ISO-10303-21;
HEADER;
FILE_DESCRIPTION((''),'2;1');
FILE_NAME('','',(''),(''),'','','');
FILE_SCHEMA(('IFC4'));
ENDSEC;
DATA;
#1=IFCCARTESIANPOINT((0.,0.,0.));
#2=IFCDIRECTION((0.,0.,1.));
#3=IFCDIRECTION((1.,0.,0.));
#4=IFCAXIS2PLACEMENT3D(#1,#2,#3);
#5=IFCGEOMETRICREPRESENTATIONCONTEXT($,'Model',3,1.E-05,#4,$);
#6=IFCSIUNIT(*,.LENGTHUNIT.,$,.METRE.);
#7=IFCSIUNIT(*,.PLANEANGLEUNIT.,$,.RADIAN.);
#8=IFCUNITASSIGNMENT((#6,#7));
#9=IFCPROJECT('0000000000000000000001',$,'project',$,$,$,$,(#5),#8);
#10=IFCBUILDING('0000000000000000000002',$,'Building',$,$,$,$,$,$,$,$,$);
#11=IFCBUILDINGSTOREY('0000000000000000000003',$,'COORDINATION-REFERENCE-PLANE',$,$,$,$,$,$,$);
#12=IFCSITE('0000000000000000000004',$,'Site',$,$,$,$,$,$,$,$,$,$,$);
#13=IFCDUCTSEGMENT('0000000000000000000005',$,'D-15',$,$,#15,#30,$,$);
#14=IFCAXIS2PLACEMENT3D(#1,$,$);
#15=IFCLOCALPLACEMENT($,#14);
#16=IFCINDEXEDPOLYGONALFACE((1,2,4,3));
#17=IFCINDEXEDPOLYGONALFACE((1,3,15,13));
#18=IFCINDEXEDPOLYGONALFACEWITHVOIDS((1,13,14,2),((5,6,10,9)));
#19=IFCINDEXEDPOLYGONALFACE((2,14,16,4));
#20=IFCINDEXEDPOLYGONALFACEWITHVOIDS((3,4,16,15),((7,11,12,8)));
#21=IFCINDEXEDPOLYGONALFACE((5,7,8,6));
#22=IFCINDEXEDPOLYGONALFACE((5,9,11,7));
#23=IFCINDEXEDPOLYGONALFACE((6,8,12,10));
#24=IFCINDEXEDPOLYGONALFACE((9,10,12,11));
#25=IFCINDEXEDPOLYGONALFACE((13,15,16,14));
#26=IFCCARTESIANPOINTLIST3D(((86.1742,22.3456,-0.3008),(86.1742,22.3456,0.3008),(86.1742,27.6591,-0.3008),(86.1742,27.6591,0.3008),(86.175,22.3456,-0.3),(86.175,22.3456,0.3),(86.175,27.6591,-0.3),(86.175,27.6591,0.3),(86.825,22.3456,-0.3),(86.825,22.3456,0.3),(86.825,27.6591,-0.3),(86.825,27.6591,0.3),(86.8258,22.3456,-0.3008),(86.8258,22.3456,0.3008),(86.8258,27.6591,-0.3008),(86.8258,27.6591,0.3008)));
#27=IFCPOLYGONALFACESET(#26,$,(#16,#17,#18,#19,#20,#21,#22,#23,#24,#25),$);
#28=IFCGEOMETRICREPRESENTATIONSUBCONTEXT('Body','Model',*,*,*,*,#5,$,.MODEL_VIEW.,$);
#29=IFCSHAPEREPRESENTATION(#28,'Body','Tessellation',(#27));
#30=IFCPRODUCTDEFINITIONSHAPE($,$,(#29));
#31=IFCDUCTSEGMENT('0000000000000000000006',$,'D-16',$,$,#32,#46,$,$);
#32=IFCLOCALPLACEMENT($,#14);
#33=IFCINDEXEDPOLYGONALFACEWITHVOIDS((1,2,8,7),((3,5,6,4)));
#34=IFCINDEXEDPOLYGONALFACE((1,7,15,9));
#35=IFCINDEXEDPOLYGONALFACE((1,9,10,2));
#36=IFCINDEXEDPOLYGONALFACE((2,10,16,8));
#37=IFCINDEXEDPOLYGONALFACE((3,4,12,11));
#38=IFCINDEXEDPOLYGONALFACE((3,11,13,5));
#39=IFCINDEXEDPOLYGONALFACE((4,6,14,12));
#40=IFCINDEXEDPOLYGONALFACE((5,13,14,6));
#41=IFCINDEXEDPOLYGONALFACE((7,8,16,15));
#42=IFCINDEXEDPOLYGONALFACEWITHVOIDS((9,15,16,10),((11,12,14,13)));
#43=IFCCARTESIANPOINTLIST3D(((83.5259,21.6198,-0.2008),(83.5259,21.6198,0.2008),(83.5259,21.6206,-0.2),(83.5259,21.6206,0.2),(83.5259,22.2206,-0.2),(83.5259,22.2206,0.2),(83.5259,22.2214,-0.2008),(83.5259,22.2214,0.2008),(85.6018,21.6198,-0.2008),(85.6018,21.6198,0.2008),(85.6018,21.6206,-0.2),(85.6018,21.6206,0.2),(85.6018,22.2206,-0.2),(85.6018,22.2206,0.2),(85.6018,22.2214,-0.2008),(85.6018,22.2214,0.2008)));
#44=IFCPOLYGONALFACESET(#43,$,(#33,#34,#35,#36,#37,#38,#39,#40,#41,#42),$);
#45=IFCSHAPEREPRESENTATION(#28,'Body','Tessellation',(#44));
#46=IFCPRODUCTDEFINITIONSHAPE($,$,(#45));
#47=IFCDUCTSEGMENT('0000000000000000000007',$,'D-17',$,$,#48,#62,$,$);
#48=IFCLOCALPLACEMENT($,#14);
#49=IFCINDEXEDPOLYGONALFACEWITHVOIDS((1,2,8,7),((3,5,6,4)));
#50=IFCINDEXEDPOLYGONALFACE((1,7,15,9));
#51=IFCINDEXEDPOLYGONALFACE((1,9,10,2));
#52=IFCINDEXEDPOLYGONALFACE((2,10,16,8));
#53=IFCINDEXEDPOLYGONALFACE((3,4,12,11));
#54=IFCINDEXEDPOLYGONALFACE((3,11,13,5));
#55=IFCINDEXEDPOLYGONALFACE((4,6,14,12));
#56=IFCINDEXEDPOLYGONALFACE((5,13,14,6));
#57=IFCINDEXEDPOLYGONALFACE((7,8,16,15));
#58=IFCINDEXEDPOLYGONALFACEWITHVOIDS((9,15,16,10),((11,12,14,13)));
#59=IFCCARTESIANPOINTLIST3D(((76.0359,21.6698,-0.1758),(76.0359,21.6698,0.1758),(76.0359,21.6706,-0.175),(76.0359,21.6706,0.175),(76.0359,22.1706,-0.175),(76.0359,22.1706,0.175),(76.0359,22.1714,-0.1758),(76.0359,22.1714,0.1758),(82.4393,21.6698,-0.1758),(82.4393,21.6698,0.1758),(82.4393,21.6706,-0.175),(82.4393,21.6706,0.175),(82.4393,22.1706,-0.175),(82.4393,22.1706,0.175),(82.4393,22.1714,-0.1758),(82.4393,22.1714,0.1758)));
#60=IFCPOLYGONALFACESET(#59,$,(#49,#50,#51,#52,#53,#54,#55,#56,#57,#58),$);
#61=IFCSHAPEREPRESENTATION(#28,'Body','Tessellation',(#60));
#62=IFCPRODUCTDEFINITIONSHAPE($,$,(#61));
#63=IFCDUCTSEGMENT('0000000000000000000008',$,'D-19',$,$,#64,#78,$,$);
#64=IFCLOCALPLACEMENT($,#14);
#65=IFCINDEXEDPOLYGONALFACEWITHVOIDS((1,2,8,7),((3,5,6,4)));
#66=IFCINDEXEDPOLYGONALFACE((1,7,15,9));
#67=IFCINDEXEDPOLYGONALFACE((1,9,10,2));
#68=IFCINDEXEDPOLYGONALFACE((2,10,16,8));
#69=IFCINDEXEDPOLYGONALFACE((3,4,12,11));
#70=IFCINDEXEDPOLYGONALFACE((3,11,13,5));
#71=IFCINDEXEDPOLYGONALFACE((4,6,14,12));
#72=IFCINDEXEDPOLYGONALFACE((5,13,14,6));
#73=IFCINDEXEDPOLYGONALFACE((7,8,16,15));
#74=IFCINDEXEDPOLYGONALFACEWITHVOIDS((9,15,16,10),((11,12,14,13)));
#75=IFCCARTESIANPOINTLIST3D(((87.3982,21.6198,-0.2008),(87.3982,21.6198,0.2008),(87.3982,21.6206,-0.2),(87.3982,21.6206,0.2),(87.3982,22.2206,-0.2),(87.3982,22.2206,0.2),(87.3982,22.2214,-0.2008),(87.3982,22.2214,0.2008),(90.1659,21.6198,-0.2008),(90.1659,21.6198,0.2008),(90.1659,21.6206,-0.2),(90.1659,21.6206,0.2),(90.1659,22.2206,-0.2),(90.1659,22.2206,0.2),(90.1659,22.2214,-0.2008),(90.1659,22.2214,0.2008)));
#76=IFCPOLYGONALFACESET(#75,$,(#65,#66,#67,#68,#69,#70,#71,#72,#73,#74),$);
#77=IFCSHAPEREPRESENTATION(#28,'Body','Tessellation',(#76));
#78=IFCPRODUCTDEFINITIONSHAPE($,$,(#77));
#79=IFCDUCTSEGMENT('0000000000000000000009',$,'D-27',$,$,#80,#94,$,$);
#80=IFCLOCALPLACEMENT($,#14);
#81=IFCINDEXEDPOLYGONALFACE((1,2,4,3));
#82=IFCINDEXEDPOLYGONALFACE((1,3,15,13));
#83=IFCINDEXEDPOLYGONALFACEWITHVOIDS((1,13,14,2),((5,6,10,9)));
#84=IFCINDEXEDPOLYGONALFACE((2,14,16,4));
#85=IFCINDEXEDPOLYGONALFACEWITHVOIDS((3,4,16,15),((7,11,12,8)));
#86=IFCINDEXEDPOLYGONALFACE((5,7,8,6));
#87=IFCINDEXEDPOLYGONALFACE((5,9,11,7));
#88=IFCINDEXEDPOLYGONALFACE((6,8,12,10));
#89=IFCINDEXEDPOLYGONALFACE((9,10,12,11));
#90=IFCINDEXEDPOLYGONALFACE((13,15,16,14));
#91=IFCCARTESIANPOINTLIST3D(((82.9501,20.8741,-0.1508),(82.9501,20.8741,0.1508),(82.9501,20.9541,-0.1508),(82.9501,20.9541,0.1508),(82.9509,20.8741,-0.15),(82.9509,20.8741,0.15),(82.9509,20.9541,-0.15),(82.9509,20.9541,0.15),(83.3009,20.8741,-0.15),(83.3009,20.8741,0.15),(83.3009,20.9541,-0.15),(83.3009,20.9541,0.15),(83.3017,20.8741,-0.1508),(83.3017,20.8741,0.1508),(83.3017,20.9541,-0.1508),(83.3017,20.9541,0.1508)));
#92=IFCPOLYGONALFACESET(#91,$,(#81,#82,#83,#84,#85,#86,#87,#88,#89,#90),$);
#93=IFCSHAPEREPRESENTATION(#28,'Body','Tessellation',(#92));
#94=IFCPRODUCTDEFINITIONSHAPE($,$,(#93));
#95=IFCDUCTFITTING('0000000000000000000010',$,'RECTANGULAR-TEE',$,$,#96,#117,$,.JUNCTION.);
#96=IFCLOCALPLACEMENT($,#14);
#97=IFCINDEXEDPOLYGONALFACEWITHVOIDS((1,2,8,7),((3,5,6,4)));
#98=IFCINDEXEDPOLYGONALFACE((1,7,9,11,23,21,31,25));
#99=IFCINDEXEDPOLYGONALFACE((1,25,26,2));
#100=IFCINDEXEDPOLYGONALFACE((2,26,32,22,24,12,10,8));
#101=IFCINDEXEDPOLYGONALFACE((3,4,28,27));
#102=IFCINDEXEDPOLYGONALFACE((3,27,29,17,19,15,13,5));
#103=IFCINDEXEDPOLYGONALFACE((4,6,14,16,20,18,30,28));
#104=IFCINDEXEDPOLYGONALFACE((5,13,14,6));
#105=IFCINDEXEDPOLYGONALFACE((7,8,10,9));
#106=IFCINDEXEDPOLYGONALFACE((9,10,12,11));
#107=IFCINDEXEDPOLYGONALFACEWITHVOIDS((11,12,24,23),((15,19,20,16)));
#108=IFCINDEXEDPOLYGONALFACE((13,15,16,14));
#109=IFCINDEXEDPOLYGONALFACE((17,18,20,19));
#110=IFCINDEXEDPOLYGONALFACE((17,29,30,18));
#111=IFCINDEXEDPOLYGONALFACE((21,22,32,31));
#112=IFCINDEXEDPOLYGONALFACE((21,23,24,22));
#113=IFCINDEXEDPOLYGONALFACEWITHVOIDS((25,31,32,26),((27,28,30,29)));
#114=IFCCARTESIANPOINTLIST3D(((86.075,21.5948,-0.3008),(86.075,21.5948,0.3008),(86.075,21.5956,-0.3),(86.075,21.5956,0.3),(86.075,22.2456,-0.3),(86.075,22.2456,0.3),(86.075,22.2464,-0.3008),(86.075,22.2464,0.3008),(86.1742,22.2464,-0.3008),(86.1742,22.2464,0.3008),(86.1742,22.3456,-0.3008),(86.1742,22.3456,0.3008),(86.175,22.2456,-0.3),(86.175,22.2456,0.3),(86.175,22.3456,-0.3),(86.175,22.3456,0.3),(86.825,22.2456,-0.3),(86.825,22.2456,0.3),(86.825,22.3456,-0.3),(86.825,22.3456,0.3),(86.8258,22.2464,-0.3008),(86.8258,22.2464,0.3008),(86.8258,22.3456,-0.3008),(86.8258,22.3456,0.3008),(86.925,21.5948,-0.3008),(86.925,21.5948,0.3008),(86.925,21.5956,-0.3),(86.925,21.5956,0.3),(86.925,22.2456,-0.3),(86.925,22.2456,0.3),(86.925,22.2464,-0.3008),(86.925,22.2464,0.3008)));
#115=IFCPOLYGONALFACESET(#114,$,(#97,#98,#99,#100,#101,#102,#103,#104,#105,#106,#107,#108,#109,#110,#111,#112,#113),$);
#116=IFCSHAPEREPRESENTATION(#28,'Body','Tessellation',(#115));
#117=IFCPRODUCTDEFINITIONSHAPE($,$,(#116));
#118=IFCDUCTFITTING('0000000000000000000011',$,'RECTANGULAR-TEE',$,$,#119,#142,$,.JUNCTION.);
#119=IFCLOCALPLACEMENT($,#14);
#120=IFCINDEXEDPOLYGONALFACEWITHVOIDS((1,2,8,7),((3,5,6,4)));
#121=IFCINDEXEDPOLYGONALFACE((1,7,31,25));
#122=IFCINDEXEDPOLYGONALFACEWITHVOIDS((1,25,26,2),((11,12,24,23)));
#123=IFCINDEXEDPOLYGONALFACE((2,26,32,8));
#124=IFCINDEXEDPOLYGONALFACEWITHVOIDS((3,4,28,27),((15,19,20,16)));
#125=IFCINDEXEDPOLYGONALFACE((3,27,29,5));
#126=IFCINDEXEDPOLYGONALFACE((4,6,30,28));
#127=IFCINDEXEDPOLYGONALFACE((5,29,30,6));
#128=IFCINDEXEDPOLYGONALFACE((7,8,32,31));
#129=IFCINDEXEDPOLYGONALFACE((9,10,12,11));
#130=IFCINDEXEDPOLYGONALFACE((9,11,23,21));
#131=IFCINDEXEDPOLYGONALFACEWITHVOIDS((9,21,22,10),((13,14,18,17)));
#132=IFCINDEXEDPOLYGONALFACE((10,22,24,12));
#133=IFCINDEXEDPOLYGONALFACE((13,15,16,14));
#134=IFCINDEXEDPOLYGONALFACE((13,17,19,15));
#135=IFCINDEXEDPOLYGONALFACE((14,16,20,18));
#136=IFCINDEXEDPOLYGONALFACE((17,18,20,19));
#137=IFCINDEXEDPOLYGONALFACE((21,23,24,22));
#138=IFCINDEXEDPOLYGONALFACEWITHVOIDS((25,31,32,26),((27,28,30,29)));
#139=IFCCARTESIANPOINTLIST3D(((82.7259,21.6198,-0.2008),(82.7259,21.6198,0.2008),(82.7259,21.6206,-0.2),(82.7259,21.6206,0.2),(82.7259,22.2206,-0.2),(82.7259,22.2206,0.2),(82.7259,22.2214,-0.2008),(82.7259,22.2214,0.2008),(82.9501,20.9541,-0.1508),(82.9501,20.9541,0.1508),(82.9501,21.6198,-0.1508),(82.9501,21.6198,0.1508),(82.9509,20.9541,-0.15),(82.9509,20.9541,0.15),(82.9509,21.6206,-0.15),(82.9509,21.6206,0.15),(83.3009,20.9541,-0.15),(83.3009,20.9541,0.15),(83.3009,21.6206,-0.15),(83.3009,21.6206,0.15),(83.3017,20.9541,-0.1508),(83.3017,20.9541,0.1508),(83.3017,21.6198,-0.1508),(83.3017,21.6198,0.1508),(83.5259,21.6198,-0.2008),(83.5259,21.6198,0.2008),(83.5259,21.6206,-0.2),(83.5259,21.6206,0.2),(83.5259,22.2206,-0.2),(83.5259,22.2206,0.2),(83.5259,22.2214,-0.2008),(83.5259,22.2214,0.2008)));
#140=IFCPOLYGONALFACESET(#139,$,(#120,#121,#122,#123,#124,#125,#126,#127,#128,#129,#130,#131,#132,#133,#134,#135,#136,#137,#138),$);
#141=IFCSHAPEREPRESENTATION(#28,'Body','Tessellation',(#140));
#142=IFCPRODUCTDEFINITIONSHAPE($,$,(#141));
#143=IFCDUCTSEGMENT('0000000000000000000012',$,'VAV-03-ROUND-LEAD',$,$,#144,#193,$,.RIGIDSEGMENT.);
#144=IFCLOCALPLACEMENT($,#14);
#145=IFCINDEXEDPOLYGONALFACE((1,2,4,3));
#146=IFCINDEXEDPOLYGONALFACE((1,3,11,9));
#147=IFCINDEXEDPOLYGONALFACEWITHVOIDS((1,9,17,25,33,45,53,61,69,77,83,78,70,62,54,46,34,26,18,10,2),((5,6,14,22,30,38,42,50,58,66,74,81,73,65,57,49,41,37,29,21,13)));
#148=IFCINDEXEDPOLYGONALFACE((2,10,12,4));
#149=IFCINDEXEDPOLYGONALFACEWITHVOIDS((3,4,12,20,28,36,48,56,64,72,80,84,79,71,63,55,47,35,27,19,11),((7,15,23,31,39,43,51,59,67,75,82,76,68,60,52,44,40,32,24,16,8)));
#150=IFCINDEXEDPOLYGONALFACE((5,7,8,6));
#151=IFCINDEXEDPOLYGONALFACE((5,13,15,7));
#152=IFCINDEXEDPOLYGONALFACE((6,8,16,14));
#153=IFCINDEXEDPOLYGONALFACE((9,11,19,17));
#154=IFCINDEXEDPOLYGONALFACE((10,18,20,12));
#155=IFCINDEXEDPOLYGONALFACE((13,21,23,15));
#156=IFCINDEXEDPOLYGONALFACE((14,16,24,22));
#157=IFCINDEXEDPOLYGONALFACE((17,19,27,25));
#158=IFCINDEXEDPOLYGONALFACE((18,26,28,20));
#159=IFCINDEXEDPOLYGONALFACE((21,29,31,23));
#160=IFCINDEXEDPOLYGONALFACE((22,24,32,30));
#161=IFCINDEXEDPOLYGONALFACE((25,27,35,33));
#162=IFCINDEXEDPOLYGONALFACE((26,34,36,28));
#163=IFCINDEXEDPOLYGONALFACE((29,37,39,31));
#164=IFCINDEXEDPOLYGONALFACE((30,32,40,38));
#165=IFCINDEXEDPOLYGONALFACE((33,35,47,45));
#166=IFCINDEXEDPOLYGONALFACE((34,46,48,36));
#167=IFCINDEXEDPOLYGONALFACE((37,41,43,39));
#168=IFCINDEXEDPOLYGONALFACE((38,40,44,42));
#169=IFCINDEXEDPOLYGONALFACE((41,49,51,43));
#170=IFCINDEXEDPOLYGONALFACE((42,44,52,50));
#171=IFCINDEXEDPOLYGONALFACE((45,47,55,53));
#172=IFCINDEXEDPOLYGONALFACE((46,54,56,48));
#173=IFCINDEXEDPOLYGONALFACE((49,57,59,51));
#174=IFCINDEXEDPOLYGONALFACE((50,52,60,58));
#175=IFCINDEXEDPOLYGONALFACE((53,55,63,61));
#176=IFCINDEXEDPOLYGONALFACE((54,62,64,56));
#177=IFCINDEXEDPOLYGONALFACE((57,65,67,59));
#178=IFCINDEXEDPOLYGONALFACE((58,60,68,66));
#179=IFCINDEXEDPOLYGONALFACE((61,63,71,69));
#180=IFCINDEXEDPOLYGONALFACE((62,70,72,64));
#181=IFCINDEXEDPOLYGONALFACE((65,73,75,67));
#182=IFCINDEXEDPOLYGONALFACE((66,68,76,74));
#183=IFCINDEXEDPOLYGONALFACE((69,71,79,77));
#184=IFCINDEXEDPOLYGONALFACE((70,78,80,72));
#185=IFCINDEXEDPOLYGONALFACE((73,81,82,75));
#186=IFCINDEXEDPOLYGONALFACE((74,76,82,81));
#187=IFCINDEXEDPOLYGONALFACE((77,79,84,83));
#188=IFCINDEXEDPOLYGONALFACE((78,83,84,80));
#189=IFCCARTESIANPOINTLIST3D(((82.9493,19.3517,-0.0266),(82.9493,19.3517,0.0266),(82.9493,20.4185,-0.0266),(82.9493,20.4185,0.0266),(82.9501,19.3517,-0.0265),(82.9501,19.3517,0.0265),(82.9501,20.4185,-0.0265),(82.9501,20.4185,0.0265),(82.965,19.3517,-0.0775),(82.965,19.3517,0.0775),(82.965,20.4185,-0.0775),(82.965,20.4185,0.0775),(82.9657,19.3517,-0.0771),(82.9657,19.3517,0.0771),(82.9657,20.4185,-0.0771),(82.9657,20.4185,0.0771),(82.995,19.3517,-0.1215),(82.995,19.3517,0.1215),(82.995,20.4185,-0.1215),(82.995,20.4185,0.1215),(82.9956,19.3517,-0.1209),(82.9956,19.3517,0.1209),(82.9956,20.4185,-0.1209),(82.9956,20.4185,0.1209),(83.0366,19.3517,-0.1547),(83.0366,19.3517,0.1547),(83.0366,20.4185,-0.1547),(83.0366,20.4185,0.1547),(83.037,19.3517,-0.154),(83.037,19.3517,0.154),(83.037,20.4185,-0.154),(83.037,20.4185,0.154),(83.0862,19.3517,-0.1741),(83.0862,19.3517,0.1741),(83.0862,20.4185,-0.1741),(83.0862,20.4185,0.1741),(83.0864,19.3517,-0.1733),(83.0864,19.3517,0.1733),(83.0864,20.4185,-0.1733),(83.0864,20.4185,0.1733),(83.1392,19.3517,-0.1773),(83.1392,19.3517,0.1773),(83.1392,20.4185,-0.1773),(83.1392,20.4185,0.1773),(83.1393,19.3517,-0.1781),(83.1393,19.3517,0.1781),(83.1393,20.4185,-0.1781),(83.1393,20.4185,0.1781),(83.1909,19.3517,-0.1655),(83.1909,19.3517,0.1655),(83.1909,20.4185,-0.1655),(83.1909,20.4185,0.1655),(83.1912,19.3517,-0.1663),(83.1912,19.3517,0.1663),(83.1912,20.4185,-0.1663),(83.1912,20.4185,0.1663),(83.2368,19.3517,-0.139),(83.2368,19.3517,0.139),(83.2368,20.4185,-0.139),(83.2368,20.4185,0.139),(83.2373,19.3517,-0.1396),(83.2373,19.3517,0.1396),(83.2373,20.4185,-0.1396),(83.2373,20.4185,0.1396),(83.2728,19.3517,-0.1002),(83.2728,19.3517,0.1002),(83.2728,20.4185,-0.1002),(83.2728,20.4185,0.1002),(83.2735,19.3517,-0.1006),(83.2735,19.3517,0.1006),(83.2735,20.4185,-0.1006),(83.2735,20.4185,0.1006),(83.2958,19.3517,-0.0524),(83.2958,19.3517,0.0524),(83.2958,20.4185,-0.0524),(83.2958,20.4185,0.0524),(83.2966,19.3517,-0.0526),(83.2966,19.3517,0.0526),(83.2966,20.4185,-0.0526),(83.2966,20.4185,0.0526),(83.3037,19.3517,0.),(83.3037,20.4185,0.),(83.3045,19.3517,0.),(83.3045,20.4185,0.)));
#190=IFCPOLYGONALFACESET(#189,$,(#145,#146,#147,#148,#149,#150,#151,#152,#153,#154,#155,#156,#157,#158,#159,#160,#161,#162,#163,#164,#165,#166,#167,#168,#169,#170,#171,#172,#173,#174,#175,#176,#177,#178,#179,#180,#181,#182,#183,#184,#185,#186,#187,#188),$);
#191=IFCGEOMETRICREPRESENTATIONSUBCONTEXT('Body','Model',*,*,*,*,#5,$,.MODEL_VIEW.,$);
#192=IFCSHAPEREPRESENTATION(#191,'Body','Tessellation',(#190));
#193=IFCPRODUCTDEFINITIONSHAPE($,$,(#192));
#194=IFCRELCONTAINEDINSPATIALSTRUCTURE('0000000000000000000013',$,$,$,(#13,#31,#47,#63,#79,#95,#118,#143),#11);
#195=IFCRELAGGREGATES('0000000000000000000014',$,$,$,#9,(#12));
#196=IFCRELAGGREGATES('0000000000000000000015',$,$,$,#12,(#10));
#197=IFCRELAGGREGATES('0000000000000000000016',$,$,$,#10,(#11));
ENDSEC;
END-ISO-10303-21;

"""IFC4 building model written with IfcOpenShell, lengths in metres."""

from ifc_helpers import new_model, si_unit, frame, origin, origin_with_axes, place, context, subcontext, project, spatial, rectangle, hollow_rectangle, hollow_circle, extrude, boolean, element, save


model = new_model("IFC4")

# Units and contexts
model_context = context("Model", 3, precision=1e-05, world=origin_with_axes())
body_context_1 = subcontext(model_context, "Body", "Model", "MODEL_VIEW")
body_context_2 = subcontext(model_context, "Body", "Model", "MODEL_VIEW")
ifc_project = project(units=[si_unit("LENGTHUNIT", "METRE"), si_unit("PLANEANGLEUNIT", "RADIAN")], contexts=[model_context])

# Site, building, storey
site = spatial("IfcSite", under=ifc_project, Name="Site")
building = spatial("IfcBuilding", under=site, Name="Building")
storey = spatial("IfcBuildingStorey", under=building, Name="COORDINATION-REFERENCE-PLANE")

# Duct segments
duct_segment_1_placement = place(None, frame((86.5, 22.3456, 0.0), z_axis=(0.0, 1.0, 0.0), x_axis=(1.0, 0.0, 0.0)))
element("IfcDuctSegment", 1, at=duct_segment_1_placement, inside=storey, Name="D-15", context=body_context_1, shape_type="SweptSolid", body=[
    extrude(hollow_rectangle(XDim=0.6516, YDim=0.6016, WallThickness=0.0008), origin(), (0.0, 0.0, 1.0), 5.3135),
])
duct_segment_2_placement = place(None, frame((83.5259, 21.9206, 0.0), z_axis=(1.0, 0.0, 0.0), x_axis=(0.0, 1.0, 0.0)))
element("IfcDuctSegment", 2, at=duct_segment_2_placement, inside=storey, Name="D-16", context=body_context_1, shape_type="SweptSolid", body=[
    extrude(hollow_rectangle(XDim=0.6016, YDim=0.4016, WallThickness=0.0008), origin(), (0.0, 0.0, 1.0), 2.0759),
])
duct_segment_3_placement = place(None, frame((76.0359, 21.9206, 0.0), z_axis=(1.0, 0.0, 0.0), x_axis=(0.0, 1.0, 0.0)))
element("IfcDuctSegment", 3, at=duct_segment_3_placement, inside=storey, Name="D-17", context=body_context_1, shape_type="SweptSolid", body=[
    extrude(hollow_rectangle(XDim=0.5016, YDim=0.3516, WallThickness=0.0008), origin(), (0.0, 0.0, 1.0), 6.4034),
])
duct_segment_4_placement = place(None, frame((87.3982, 21.9206, 0.0), z_axis=(1.0, 0.0, 0.0), x_axis=(0.0, 1.0, 0.0)))
element("IfcDuctSegment", 4, at=duct_segment_4_placement, inside=storey, Name="D-19", context=body_context_1, shape_type="SweptSolid", body=[
    extrude(hollow_rectangle(XDim=0.6016, YDim=0.4016, WallThickness=0.0008), origin(), (0.0, 0.0, 1.0), 2.7677),
])
duct_segment_5_placement = place(None, frame((83.1259, 20.8741, 0.0), z_axis=(0.0, 1.0, 0.0), x_axis=(1.0, 0.0, 0.0)))
element("IfcDuctSegment", 5, at=duct_segment_5_placement, inside=storey, Name="D-27", context=body_context_1, shape_type="SweptSolid", body=[
    extrude(hollow_rectangle(XDim=0.3516, YDim=0.3016, WallThickness=0.0008), origin(), (0.0, 0.0, 1.0), 0.08),
])

# Duct fittings
duct_fitting_1_placement = place(None, frame((86.5, 21.9206, 0.0), z_axis=(1.0, 0.0, 0.0), x_axis=(0.0, 1.0, 0.0)))
solid_1 = boolean("UNION", extrude(rectangle(XDim=0.65, YDim=0.6), frame((0.0, 0.0, -0.425), z_axis=(0.0, 0.0, 1.0), x_axis=(1.0, 0.0, 0.0)), (0.0, 0.0, 1.0), 0.85), extrude(rectangle(XDim=0.65, YDim=0.6), frame((0.0, 0.0, 0.0), z_axis=(1.0, 0.0, 0.0), x_axis=(0.0, 0.0, -1.0)), (0.0, 0.0, 1.0), 0.425))
element("IfcDuctFitting", 6, at=duct_fitting_1_placement, inside=storey, Name="RECTANGULAR-TEE", PredefinedType="JUNCTION", context=body_context_1, shape_type="CSG", body=[
    boolean("DIFFERENCE", boolean("UNION", extrude(rectangle(XDim=0.6516, YDim=0.6016), frame((0.0, 0.0, -0.425), z_axis=(0.0, 0.0, 1.0), x_axis=(1.0, 0.0, 0.0)), (0.0, 0.0, 1.0), 0.85), extrude(rectangle(XDim=0.6516, YDim=0.6016), frame((0.0, 0.0, 0.0), z_axis=(1.0, 0.0, 0.0), x_axis=(0.0, 0.0, -1.0)), (0.0, 0.0, 1.0), 0.425)), solid_1),
])
duct_fitting_2_placement = place(None, frame((83.1259, 21.9206, 0.0), z_axis=(-1.0, 0.0, 0.0), x_axis=(0.0, -1.0, 0.0)))
solid_2 = boolean("UNION", extrude(rectangle(XDim=0.6, YDim=0.4), frame((0.0, 0.0, -0.4), z_axis=(0.0, 0.0, 1.0), x_axis=(1.0, 0.0, 0.0)), (0.0, 0.0, 1.0), 0.8), extrude(rectangle(XDim=0.35, YDim=0.3), frame((0.0, 0.0, 0.0), z_axis=(1.0, 0.0, 0.0), x_axis=(0.0, 0.0, -1.0)), (0.0, 0.0, 1.0), 0.9665))
element("IfcDuctFitting", 7, at=duct_fitting_2_placement, inside=storey, Name="RECTANGULAR-TEE", PredefinedType="JUNCTION", context=body_context_1, shape_type="CSG", body=[
    boolean("DIFFERENCE", boolean("UNION", extrude(rectangle(XDim=0.6016, YDim=0.4016), frame((0.0, 0.0, -0.4), z_axis=(0.0, 0.0, 1.0), x_axis=(1.0, 0.0, 0.0)), (0.0, 0.0, 1.0), 0.8), extrude(rectangle(XDim=0.3516, YDim=0.3016), frame((0.0, 0.0, 0.0), z_axis=(1.0, 0.0, 0.0), x_axis=(0.0, 0.0, -1.0)), (0.0, 0.0, 1.0), 0.9665)), solid_2),
])

# Duct segment
duct_segment_6_placement = place(None, frame((83.1259, 20.4185, 0.0), z_axis=(0.0, -1.0, 0.0), x_axis=(1.0, 0.0, 0.0)))
element("IfcDuctSegment", 8, at=duct_segment_6_placement, inside=storey, Name="VAV-03-ROUND-LEAD", PredefinedType="RIGIDSEGMENT", context=body_context_2, shape_type="SweptSolid", body=[
    extrude(hollow_circle(Radius=0.1786, WallThickness=0.0008), origin(), (0.0, 0.0, 1.0), 1.0668),
])

save(model, "model.ifc")
